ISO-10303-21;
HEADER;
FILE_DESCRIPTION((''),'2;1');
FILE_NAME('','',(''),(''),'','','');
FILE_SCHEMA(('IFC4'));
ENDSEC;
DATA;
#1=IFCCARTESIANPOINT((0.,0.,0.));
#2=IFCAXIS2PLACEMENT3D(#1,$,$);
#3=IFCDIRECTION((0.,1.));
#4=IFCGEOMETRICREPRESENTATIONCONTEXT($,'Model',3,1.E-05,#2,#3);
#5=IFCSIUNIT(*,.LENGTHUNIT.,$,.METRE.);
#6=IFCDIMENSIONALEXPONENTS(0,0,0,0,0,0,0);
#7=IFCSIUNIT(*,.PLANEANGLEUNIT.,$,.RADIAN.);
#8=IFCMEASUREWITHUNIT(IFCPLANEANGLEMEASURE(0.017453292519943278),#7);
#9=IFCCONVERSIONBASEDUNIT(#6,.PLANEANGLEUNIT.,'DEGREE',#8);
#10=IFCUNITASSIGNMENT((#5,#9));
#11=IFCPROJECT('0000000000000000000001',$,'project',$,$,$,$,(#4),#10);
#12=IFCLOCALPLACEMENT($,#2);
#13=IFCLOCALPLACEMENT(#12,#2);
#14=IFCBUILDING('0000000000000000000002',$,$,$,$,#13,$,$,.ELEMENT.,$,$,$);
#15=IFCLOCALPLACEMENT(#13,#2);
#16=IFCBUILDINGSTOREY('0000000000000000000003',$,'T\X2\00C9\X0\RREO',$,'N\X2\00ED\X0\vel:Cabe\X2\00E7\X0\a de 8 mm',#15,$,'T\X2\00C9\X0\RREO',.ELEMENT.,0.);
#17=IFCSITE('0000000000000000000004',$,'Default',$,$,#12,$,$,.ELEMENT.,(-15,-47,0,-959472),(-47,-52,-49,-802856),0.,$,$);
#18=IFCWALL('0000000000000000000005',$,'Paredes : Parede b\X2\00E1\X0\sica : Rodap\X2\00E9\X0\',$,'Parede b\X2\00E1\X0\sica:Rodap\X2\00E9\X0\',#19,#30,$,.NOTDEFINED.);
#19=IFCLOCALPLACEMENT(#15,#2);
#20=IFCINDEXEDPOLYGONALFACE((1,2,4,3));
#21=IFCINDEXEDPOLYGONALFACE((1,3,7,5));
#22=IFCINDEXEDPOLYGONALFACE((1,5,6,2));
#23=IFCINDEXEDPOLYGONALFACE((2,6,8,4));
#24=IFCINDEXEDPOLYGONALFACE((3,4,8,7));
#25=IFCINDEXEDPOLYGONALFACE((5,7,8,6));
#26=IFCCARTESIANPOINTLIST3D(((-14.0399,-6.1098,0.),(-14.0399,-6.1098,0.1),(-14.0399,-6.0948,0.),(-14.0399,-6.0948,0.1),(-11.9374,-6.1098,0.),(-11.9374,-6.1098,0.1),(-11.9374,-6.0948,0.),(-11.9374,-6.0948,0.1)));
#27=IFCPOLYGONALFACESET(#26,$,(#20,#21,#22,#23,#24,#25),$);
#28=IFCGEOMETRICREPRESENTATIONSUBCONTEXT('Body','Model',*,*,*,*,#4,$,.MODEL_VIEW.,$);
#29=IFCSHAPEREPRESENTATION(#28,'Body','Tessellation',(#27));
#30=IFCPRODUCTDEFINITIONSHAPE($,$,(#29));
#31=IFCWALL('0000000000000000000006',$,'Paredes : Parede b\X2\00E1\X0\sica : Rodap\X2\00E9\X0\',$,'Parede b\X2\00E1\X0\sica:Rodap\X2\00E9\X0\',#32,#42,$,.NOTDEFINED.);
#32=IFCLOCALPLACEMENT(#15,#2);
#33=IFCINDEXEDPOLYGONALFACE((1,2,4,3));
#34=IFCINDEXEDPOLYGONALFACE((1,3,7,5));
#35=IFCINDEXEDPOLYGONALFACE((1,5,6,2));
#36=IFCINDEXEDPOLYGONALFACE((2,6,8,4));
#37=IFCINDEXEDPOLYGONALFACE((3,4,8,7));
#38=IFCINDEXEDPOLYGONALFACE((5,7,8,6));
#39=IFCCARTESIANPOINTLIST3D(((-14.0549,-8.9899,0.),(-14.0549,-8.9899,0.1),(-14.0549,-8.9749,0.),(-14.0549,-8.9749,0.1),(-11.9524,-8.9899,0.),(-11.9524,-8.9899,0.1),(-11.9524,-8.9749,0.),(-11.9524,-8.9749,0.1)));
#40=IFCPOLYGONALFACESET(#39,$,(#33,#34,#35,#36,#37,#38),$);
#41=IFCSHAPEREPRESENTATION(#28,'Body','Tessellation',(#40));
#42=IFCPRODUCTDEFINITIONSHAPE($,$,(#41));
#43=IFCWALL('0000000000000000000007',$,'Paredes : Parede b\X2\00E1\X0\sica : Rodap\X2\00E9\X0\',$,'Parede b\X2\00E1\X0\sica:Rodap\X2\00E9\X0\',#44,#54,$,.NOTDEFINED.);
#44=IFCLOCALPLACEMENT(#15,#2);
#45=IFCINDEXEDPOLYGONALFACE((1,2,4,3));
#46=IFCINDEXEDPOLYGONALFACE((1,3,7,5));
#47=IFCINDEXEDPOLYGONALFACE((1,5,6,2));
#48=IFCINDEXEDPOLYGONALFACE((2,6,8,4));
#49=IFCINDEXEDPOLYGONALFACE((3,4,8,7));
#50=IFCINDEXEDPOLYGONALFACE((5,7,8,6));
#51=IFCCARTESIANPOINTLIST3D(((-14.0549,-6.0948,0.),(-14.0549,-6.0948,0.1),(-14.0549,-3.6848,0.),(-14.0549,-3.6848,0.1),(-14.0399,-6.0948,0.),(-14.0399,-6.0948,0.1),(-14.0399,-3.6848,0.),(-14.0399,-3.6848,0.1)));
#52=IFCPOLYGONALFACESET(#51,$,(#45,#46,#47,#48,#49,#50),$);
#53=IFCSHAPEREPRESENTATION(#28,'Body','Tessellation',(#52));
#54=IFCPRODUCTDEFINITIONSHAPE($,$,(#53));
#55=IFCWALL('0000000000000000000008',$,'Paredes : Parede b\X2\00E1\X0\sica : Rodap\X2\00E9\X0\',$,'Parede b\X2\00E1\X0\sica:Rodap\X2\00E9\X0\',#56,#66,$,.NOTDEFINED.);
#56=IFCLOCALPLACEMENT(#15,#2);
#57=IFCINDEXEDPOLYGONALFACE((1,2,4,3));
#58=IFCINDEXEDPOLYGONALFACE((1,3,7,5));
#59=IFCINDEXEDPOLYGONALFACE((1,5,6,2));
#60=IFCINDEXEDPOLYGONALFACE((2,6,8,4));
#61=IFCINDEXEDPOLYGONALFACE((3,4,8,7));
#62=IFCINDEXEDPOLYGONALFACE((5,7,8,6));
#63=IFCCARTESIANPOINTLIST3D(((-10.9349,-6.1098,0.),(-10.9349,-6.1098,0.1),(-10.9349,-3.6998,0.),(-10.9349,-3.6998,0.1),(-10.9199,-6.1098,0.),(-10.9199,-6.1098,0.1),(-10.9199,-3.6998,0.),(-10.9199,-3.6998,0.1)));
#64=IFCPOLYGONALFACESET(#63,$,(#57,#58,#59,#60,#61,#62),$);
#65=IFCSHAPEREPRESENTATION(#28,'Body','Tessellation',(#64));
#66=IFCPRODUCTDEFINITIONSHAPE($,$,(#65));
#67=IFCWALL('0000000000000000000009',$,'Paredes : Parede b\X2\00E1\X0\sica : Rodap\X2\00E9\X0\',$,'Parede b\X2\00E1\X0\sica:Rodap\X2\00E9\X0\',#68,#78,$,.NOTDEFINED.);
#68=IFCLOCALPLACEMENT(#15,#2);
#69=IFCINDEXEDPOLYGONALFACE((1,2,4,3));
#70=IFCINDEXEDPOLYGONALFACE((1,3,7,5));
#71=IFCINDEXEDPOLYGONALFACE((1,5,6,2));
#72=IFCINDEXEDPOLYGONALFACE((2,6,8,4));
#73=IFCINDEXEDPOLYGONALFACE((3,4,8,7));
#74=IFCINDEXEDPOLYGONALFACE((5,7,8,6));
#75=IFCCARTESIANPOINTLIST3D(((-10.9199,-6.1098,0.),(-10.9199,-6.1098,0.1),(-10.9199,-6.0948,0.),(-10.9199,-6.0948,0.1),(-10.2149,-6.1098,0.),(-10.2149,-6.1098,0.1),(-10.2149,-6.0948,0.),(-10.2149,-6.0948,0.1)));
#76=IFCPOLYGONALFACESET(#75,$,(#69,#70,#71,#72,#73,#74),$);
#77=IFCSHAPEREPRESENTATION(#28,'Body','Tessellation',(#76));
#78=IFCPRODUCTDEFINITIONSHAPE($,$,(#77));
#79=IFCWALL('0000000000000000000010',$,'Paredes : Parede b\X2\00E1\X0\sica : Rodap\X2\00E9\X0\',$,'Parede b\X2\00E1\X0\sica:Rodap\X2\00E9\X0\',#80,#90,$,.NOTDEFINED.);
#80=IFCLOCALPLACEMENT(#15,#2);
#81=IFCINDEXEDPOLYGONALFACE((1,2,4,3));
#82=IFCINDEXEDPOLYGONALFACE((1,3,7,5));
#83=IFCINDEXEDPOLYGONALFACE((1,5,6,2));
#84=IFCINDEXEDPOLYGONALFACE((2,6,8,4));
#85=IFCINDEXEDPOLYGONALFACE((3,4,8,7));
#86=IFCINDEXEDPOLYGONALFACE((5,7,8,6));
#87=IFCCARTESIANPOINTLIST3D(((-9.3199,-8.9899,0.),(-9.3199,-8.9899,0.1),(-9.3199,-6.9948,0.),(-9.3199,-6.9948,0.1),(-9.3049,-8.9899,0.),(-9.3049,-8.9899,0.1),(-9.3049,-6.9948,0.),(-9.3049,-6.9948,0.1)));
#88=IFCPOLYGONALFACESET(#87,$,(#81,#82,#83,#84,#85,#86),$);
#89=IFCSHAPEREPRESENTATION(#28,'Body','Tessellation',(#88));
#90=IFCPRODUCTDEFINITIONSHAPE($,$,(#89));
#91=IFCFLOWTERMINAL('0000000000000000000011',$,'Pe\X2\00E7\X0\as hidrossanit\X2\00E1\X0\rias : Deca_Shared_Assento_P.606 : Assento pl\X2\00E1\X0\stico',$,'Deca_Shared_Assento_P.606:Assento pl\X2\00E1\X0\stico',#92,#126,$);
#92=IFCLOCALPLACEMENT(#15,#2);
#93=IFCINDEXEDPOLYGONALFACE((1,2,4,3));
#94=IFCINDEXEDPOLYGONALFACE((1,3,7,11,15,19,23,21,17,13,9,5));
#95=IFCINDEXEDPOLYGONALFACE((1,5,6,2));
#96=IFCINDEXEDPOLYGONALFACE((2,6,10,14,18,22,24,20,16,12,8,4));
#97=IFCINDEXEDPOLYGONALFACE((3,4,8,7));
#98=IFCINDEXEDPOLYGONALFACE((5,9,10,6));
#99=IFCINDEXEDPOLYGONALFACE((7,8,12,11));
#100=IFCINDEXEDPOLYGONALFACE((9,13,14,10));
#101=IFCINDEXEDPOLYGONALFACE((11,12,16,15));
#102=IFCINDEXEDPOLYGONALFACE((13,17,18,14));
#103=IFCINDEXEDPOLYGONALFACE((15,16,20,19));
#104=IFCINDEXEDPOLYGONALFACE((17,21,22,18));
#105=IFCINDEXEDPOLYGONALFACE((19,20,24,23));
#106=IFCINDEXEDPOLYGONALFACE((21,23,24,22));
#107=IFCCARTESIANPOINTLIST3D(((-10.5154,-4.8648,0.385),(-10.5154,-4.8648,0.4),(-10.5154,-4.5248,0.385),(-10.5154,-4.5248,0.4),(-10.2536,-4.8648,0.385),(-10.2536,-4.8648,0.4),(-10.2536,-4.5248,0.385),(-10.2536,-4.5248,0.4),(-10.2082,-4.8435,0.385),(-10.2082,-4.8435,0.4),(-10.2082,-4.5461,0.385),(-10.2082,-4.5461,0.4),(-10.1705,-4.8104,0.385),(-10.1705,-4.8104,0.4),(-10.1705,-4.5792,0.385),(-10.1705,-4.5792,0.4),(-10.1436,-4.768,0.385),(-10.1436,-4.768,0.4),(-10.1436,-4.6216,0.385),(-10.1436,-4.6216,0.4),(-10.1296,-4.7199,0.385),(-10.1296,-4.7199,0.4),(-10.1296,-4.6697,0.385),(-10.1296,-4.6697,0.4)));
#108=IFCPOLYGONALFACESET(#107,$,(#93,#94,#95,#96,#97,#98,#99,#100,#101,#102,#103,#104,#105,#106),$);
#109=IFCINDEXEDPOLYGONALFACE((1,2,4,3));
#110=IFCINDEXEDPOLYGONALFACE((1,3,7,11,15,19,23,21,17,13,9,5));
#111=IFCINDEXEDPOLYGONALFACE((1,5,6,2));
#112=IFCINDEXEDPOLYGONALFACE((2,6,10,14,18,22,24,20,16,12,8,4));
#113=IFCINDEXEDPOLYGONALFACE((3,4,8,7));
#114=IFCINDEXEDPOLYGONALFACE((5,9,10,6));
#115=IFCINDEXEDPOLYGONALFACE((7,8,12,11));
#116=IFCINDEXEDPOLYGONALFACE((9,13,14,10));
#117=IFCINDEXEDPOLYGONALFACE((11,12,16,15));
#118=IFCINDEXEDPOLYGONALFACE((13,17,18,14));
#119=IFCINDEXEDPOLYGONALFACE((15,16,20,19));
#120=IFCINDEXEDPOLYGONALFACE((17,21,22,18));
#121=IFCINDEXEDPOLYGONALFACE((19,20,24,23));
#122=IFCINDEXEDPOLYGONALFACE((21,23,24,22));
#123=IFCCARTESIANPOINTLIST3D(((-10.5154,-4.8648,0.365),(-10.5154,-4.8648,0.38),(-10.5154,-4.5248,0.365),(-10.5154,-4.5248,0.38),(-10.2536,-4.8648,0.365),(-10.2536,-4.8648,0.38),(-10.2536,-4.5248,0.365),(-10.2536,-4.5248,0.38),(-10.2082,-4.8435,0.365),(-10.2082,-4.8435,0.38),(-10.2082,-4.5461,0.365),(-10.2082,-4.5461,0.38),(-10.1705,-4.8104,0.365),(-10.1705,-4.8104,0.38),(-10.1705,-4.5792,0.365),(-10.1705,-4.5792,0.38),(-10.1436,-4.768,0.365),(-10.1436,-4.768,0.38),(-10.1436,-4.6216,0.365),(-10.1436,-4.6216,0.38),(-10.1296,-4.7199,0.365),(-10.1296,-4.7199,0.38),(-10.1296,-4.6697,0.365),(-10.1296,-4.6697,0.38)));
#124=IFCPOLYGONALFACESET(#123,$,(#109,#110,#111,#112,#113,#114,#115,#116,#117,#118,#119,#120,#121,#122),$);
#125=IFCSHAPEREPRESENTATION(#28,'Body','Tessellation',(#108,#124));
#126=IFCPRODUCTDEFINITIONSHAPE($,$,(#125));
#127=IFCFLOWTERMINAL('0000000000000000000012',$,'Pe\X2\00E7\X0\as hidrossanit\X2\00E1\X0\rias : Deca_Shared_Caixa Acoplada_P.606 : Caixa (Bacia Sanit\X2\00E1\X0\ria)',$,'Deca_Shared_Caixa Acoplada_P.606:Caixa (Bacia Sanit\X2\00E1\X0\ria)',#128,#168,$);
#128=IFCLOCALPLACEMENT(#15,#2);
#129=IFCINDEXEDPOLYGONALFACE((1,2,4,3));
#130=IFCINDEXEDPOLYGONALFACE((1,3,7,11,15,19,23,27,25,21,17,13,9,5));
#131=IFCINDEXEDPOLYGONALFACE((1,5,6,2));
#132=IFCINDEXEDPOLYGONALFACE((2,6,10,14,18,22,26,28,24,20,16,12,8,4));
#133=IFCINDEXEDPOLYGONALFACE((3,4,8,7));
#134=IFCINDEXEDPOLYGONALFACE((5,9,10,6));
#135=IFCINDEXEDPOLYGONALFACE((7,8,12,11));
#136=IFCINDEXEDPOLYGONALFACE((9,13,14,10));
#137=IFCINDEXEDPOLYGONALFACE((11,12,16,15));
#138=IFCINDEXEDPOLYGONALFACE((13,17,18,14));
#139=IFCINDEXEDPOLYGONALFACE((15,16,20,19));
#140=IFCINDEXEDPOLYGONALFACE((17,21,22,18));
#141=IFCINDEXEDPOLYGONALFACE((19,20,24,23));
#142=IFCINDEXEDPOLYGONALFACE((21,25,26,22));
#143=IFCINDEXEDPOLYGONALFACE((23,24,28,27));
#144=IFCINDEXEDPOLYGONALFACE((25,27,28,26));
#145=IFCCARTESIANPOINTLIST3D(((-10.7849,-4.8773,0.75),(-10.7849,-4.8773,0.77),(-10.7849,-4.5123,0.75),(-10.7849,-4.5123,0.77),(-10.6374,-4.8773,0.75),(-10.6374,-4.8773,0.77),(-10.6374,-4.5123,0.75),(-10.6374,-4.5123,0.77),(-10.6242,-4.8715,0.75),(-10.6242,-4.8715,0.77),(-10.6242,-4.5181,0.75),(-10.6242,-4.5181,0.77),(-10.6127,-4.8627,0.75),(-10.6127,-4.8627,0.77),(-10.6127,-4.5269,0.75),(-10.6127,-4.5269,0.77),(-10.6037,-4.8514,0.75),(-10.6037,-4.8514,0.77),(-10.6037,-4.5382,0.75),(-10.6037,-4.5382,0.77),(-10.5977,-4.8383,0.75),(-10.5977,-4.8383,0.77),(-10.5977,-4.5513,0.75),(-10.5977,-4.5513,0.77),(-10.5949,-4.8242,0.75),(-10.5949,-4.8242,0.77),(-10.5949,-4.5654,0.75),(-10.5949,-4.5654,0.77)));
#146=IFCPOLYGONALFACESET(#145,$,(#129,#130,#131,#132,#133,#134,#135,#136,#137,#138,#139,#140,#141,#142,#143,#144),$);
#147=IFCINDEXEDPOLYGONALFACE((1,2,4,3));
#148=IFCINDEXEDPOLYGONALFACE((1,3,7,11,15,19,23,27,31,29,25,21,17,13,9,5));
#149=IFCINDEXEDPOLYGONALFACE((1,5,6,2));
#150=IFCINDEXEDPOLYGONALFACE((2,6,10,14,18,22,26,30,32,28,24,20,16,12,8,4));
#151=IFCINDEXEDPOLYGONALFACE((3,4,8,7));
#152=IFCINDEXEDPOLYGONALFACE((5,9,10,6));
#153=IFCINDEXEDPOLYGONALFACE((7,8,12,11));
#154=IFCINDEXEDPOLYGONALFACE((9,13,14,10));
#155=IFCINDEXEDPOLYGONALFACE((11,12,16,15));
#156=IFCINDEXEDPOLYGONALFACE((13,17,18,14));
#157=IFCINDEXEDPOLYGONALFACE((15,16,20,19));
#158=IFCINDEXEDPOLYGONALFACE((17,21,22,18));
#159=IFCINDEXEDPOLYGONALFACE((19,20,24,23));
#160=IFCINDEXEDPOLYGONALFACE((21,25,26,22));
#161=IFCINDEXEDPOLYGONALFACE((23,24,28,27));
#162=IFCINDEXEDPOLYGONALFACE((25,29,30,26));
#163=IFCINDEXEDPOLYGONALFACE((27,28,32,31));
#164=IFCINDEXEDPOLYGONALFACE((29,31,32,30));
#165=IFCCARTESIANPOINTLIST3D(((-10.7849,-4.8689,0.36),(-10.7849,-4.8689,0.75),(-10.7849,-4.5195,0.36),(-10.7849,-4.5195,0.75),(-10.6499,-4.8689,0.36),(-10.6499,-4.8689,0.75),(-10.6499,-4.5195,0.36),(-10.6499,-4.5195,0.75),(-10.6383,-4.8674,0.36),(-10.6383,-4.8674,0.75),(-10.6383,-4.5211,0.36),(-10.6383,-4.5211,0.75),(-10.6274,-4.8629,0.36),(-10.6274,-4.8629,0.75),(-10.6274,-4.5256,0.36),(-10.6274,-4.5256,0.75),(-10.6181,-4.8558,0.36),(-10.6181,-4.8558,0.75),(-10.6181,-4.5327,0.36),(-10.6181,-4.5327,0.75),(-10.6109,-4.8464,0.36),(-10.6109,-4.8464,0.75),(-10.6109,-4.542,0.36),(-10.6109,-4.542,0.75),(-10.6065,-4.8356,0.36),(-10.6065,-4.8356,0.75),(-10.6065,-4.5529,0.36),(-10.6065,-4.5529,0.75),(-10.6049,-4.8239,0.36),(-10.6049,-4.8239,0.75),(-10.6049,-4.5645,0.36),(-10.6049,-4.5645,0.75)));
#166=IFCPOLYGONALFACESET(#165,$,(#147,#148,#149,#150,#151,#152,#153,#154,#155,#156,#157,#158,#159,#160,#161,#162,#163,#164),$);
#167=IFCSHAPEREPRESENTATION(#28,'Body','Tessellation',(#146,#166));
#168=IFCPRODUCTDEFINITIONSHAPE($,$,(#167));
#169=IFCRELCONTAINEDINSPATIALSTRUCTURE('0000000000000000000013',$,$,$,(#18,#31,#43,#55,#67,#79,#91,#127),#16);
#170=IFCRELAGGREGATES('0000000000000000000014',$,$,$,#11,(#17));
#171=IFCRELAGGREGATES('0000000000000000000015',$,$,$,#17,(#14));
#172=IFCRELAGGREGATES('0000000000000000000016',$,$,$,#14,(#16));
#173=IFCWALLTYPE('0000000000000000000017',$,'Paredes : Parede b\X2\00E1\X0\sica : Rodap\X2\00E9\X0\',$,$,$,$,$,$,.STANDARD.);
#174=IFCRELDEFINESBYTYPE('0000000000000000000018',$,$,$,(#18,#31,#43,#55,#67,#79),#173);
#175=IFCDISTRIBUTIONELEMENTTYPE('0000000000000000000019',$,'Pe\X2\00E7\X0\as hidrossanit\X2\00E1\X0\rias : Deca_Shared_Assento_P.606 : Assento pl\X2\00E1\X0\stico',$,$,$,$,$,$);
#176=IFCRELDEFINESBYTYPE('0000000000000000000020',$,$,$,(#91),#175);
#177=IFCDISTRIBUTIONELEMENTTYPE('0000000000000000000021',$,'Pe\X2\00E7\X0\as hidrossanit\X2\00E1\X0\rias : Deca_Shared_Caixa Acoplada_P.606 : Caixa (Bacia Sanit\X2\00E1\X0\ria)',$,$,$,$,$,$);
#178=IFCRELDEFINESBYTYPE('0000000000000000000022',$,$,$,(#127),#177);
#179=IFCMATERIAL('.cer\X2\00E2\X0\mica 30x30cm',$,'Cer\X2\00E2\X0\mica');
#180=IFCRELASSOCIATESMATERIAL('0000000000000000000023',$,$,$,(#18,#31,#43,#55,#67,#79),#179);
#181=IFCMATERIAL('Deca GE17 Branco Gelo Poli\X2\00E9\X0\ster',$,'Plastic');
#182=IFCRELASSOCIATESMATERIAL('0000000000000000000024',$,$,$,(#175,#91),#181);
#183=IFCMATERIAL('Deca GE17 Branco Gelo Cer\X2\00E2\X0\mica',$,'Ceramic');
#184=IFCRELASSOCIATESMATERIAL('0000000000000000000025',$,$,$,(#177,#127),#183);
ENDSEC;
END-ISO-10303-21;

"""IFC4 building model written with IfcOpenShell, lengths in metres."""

from ifc_helpers import new_model, entity, si_unit, converted_unit, direction, frame, origin, place, context, subcontext, project, spatial, line, arc, indexed_curve, outline, extrude, source, transform, mapped, material, type_object, type_shapes, element, save


model = new_model("IFC4")

# Units and contexts
model_context = context("Model", 3, precision=1e-05, world=origin(), true_north=direction((0.0, 1.0)))
body_context = subcontext(model_context, "Body", "Model", "MODEL_VIEW")
ifc_project = project(units=[si_unit("LENGTHUNIT", "METRE"), converted_unit("PLANEANGLEUNIT", "DEGREE", entity("IfcPlaneAngleMeasure", 0.017453292519943278), si_unit("PLANEANGLEUNIT", "RADIAN"), dimensions=[0, 0, 0, 0, 0, 0, 0])], contexts=[model_context])

# Site, building, storey
site_placement = place(None, origin())
site = spatial("IfcSite", under=ifc_project, at=site_placement, Name="Default", CompositionType="ELEMENT", RefLatitude=(-15, -47, 0, -959472), RefLongitude=(-47, -52, -49, -802856), RefElevation=0.0)
building_placement = place(site_placement, origin())
building = spatial("IfcBuilding", under=site, at=building_placement, CompositionType="ELEMENT")
storey_placement = place(building_placement, origin())
storey = spatial("IfcBuildingStorey", under=building, at=storey_placement, Name="TÉRREO", ObjectType="Nível:Cabeça de 8 mm", LongName="TÉRREO", CompositionType="ELEMENT", Elevation=0.0)

# Shared definitions
ifc_material_1 = material(Name=".cerâmica 30x30cm", Category="Cerâmica")

# Walls
wall_type_1 = type_object("IfcWallType", Name="Paredes : Parede básica : Rodapé", PredefinedType="STANDARD")
wall_1_placement = place(storey_placement, frame((-14.0399, -6.1023, 0.0)))
element("IfcWall", 1, at=wall_1_placement, inside=storey, type_object=wall_type_1, material=ifc_material_1, Name="Paredes : Parede básica : Rodapé", ObjectType="Parede básica:Rodapé", PredefinedType="NOTDEFINED", context=body_context, shape_type="SweptSolid", body=[
    extrude(outline(indexed_curve([(2.1025, 0.0075), (0.0, 0.0075), (0.0, -0.0075), (2.1025, -0.0075), (2.1025, 0.0075)], self_intersect=False)), origin(), (0.0, 0.0, 1.0), 0.1),
])
wall_2_placement = place(storey_placement, frame((-11.9524, -8.9824, 0.0), z_axis=(0.0, 0.0, 1.0), x_axis=(-1.0, 0.0, 0.0)))
element("IfcWall", 2, at=wall_2_placement, inside=storey, type_object=wall_type_1, material=ifc_material_1, Name="Paredes : Parede básica : Rodapé", ObjectType="Parede básica:Rodapé", PredefinedType="NOTDEFINED", context=body_context, shape_type="SweptSolid", body=[
    extrude(outline(indexed_curve([(2.1025, 0.0075), (0.0, 0.0075), (0.0, -0.0075), (2.1025, -0.0075), (2.1025, 0.0075)], self_intersect=False)), origin(), (0.0, 0.0, 1.0), 0.1),
])
wall_3_placement = place(storey_placement, frame((-14.0474, -6.0948, 0.0), z_axis=(0.0, 0.0, 1.0), x_axis=(0.0, 1.0, 0.0)))
element("IfcWall", 3, at=wall_3_placement, inside=storey, type_object=wall_type_1, material=ifc_material_1, Name="Paredes : Parede básica : Rodapé", ObjectType="Parede básica:Rodapé", PredefinedType="NOTDEFINED", context=body_context, shape_type="SweptSolid", body=[
    extrude(outline(indexed_curve([(2.41, 0.0075), (0.0, 0.0075), (0.0, -0.0075), (2.41, -0.0075), (2.41, 0.0075)], self_intersect=False)), origin(), (0.0, 0.0, 1.0), 0.1),
])
wall_4_placement = place(storey_placement, frame((-10.9274, -3.6998, 0.0), z_axis=(0.0, 0.0, 1.0), x_axis=(0.0, -1.0, 0.0)))
element("IfcWall", 4, at=wall_4_placement, inside=storey, type_object=wall_type_1, material=ifc_material_1, Name="Paredes : Parede básica : Rodapé", ObjectType="Parede básica:Rodapé", PredefinedType="NOTDEFINED", context=body_context, shape_type="SweptSolid", body=[
    extrude(outline(indexed_curve([(2.41, 0.0075), (0.0, 0.0075), (0.0, -0.0075), (2.41, -0.0075), (2.41, 0.0075)], self_intersect=False)), origin(), (0.0, 0.0, 1.0), 0.1),
])
wall_5_placement = place(storey_placement, frame((-10.9199, -6.1023, 0.0)))
element("IfcWall", 5, at=wall_5_placement, inside=storey, type_object=wall_type_1, material=ifc_material_1, Name="Paredes : Parede básica : Rodapé", ObjectType="Parede básica:Rodapé", PredefinedType="NOTDEFINED", context=body_context, shape_type="SweptSolid", body=[
    extrude(outline(indexed_curve([(0.705, 0.0075), (0.0, 0.0075), (0.0, -0.0075), (0.705, -0.0075), (0.705, 0.0075)], self_intersect=False)), origin(), (0.0, 0.0, 1.0), 0.1),
])
wall_6_placement = place(storey_placement, frame((-9.3124, -6.9948, 0.0), z_axis=(0.0, 0.0, 1.0), x_axis=(0.0, -1.0, 0.0)))
element("IfcWall", 6, at=wall_6_placement, inside=storey, type_object=wall_type_1, material=ifc_material_1, Name="Paredes : Parede básica : Rodapé", ObjectType="Parede básica:Rodapé", PredefinedType="NOTDEFINED", context=body_context, shape_type="SweptSolid", body=[
    extrude(outline(indexed_curve([(1.9951, 0.0075), (0.0, 0.0075), (0.0, -0.0075), (1.9951, -0.0075), (1.9951, 0.0075)], self_intersect=False)), origin(), (0.0, 0.0, 1.0), 0.1),
])

# Flow terminals
ifc_material_2 = material(Name="Deca GE17 Branco Gelo Poliéster", Category="Plastic")
distribution_element_type_1 = type_object("IfcDistributionElementType", Name="Peças hidrossanitárias : Deca_Shared_Assento_P.606 : Assento plástico", material=ifc_material_2)
shared_shape_1 = source(origin(), body_context, "Body", "SweptSolid", [
    extrude(outline(indexed_curve([(-0.1309, -0.17), (0.1309, -0.17), (0.1309, 0.17), (-0.1309, 0.17), (-0.2566, 0.0)], segments=[line(1, 2, 3, 4), arc(4, 5, 1)], self_intersect=False)), frame((0.0, 0.02, 0.1309), z_axis=(0.0, 1.0, 0.0), x_axis=(0.0, 0.0, -1.0)), (0.0, 0.0, 1.0), 0.015),
    extrude(outline(indexed_curve([(-0.17, -0.1309), (0.0, -0.2566), (0.17, -0.1309), (0.17, 0.1309), (-0.17, 0.1309)], segments=[arc(1, 2, 3), line(3, 4, 5, 1)], self_intersect=False)), frame((0.0, 0.0, 0.1309), z_axis=(0.0, 1.0, 0.0), x_axis=(1.0, 0.0, 0.0)), (0.0, 0.0, 1.0), 0.015),
])
type_shapes(distribution_element_type_1, [shared_shape_1])
flow_terminal_1_placement = place(storey_placement, frame((-10.5154, -4.6948, 0.365), z_axis=(1.0, 0.0, 0.0), x_axis=(0.0, 1.0, 0.0)))
element("IfcFlowTerminal", 7, at=flow_terminal_1_placement, inside=storey, type_object=distribution_element_type_1, material=ifc_material_2, Name="Peças hidrossanitárias : Deca_Shared_Assento_P.606 : Assento plástico", ObjectType="Deca_Shared_Assento_P.606:Assento plástico", context=body_context, shape_type="MappedRepresentation", body=[
    mapped(shared_shape_1, transform((0.0, 0.0, 0.0), scale=1.0)),
])
ifc_material_3 = material(Name="Deca GE17 Branco Gelo Cerâmica", Category="Ceramic")
distribution_element_type_2 = type_object("IfcDistributionElementType", Name="Peças hidrossanitárias : Deca_Shared_Caixa Acoplada_P.606 : Caixa (Bacia Sanitária)", material=ifc_material_3)
shared_shape_2 = source(origin(), body_context, "Body", "SweptSolid", [
    extrude(outline(indexed_curve([(-0.1825, -0.1125), (0.1825, -0.1125), (0.1825, 0.035), (0.1625, 0.0645), (0.1294, 0.0775), (-0.1294, 0.0775), (-0.1625, 0.0645), (-0.1825, 0.035)], segments=[line(1, 2, 3), arc(3, 4, 5), line(5, 6), arc(6, 7, 8), line(8, 1)], self_intersect=False)), frame((-0.0006, 0.39, 0.1125), z_axis=(0.0, 1.0, 0.0), x_axis=(-1.0, 0.0, 0.0)), (0.0, 0.0, 1.0), 0.02),
    extrude(outline(indexed_curve([(-0.1747, -0.105), (0.1747, -0.105), (0.1747, 0.03), (0.1615, 0.0618), (0.1297, 0.075), (-0.1297, 0.075), (-0.1615, 0.0618), (-0.1747, 0.03)], segments=[line(1, 2, 3), arc(3, 4, 5), line(5, 6), arc(6, 7, 8), line(8, 1)], self_intersect=False)), frame((0.0, 0.0, 0.105), z_axis=(0.0, 1.0, 0.0), x_axis=(-1.0, 0.0, 0.0)), (0.0, 0.0, 1.0), 0.39),
])
type_shapes(distribution_element_type_2, [shared_shape_2])
flow_terminal_2_placement = place(storey_placement, frame((-10.7849, -4.6942, 0.36), z_axis=(1.0, 0.0, 0.0), x_axis=(0.0, 1.0, 0.0)))
element("IfcFlowTerminal", 8, at=flow_terminal_2_placement, inside=storey, type_object=distribution_element_type_2, material=ifc_material_3, Name="Peças hidrossanitárias : Deca_Shared_Caixa Acoplada_P.606 : Caixa (Bacia Sanitária)", ObjectType="Deca_Shared_Caixa Acoplada_P.606:Caixa (Bacia Sanitária)", context=body_context, shape_type="MappedRepresentation", body=[
    mapped(shared_shape_2, transform((0.0, 0.0, 0.0), scale=1.0)),
])

save(model, "model.ifc")
